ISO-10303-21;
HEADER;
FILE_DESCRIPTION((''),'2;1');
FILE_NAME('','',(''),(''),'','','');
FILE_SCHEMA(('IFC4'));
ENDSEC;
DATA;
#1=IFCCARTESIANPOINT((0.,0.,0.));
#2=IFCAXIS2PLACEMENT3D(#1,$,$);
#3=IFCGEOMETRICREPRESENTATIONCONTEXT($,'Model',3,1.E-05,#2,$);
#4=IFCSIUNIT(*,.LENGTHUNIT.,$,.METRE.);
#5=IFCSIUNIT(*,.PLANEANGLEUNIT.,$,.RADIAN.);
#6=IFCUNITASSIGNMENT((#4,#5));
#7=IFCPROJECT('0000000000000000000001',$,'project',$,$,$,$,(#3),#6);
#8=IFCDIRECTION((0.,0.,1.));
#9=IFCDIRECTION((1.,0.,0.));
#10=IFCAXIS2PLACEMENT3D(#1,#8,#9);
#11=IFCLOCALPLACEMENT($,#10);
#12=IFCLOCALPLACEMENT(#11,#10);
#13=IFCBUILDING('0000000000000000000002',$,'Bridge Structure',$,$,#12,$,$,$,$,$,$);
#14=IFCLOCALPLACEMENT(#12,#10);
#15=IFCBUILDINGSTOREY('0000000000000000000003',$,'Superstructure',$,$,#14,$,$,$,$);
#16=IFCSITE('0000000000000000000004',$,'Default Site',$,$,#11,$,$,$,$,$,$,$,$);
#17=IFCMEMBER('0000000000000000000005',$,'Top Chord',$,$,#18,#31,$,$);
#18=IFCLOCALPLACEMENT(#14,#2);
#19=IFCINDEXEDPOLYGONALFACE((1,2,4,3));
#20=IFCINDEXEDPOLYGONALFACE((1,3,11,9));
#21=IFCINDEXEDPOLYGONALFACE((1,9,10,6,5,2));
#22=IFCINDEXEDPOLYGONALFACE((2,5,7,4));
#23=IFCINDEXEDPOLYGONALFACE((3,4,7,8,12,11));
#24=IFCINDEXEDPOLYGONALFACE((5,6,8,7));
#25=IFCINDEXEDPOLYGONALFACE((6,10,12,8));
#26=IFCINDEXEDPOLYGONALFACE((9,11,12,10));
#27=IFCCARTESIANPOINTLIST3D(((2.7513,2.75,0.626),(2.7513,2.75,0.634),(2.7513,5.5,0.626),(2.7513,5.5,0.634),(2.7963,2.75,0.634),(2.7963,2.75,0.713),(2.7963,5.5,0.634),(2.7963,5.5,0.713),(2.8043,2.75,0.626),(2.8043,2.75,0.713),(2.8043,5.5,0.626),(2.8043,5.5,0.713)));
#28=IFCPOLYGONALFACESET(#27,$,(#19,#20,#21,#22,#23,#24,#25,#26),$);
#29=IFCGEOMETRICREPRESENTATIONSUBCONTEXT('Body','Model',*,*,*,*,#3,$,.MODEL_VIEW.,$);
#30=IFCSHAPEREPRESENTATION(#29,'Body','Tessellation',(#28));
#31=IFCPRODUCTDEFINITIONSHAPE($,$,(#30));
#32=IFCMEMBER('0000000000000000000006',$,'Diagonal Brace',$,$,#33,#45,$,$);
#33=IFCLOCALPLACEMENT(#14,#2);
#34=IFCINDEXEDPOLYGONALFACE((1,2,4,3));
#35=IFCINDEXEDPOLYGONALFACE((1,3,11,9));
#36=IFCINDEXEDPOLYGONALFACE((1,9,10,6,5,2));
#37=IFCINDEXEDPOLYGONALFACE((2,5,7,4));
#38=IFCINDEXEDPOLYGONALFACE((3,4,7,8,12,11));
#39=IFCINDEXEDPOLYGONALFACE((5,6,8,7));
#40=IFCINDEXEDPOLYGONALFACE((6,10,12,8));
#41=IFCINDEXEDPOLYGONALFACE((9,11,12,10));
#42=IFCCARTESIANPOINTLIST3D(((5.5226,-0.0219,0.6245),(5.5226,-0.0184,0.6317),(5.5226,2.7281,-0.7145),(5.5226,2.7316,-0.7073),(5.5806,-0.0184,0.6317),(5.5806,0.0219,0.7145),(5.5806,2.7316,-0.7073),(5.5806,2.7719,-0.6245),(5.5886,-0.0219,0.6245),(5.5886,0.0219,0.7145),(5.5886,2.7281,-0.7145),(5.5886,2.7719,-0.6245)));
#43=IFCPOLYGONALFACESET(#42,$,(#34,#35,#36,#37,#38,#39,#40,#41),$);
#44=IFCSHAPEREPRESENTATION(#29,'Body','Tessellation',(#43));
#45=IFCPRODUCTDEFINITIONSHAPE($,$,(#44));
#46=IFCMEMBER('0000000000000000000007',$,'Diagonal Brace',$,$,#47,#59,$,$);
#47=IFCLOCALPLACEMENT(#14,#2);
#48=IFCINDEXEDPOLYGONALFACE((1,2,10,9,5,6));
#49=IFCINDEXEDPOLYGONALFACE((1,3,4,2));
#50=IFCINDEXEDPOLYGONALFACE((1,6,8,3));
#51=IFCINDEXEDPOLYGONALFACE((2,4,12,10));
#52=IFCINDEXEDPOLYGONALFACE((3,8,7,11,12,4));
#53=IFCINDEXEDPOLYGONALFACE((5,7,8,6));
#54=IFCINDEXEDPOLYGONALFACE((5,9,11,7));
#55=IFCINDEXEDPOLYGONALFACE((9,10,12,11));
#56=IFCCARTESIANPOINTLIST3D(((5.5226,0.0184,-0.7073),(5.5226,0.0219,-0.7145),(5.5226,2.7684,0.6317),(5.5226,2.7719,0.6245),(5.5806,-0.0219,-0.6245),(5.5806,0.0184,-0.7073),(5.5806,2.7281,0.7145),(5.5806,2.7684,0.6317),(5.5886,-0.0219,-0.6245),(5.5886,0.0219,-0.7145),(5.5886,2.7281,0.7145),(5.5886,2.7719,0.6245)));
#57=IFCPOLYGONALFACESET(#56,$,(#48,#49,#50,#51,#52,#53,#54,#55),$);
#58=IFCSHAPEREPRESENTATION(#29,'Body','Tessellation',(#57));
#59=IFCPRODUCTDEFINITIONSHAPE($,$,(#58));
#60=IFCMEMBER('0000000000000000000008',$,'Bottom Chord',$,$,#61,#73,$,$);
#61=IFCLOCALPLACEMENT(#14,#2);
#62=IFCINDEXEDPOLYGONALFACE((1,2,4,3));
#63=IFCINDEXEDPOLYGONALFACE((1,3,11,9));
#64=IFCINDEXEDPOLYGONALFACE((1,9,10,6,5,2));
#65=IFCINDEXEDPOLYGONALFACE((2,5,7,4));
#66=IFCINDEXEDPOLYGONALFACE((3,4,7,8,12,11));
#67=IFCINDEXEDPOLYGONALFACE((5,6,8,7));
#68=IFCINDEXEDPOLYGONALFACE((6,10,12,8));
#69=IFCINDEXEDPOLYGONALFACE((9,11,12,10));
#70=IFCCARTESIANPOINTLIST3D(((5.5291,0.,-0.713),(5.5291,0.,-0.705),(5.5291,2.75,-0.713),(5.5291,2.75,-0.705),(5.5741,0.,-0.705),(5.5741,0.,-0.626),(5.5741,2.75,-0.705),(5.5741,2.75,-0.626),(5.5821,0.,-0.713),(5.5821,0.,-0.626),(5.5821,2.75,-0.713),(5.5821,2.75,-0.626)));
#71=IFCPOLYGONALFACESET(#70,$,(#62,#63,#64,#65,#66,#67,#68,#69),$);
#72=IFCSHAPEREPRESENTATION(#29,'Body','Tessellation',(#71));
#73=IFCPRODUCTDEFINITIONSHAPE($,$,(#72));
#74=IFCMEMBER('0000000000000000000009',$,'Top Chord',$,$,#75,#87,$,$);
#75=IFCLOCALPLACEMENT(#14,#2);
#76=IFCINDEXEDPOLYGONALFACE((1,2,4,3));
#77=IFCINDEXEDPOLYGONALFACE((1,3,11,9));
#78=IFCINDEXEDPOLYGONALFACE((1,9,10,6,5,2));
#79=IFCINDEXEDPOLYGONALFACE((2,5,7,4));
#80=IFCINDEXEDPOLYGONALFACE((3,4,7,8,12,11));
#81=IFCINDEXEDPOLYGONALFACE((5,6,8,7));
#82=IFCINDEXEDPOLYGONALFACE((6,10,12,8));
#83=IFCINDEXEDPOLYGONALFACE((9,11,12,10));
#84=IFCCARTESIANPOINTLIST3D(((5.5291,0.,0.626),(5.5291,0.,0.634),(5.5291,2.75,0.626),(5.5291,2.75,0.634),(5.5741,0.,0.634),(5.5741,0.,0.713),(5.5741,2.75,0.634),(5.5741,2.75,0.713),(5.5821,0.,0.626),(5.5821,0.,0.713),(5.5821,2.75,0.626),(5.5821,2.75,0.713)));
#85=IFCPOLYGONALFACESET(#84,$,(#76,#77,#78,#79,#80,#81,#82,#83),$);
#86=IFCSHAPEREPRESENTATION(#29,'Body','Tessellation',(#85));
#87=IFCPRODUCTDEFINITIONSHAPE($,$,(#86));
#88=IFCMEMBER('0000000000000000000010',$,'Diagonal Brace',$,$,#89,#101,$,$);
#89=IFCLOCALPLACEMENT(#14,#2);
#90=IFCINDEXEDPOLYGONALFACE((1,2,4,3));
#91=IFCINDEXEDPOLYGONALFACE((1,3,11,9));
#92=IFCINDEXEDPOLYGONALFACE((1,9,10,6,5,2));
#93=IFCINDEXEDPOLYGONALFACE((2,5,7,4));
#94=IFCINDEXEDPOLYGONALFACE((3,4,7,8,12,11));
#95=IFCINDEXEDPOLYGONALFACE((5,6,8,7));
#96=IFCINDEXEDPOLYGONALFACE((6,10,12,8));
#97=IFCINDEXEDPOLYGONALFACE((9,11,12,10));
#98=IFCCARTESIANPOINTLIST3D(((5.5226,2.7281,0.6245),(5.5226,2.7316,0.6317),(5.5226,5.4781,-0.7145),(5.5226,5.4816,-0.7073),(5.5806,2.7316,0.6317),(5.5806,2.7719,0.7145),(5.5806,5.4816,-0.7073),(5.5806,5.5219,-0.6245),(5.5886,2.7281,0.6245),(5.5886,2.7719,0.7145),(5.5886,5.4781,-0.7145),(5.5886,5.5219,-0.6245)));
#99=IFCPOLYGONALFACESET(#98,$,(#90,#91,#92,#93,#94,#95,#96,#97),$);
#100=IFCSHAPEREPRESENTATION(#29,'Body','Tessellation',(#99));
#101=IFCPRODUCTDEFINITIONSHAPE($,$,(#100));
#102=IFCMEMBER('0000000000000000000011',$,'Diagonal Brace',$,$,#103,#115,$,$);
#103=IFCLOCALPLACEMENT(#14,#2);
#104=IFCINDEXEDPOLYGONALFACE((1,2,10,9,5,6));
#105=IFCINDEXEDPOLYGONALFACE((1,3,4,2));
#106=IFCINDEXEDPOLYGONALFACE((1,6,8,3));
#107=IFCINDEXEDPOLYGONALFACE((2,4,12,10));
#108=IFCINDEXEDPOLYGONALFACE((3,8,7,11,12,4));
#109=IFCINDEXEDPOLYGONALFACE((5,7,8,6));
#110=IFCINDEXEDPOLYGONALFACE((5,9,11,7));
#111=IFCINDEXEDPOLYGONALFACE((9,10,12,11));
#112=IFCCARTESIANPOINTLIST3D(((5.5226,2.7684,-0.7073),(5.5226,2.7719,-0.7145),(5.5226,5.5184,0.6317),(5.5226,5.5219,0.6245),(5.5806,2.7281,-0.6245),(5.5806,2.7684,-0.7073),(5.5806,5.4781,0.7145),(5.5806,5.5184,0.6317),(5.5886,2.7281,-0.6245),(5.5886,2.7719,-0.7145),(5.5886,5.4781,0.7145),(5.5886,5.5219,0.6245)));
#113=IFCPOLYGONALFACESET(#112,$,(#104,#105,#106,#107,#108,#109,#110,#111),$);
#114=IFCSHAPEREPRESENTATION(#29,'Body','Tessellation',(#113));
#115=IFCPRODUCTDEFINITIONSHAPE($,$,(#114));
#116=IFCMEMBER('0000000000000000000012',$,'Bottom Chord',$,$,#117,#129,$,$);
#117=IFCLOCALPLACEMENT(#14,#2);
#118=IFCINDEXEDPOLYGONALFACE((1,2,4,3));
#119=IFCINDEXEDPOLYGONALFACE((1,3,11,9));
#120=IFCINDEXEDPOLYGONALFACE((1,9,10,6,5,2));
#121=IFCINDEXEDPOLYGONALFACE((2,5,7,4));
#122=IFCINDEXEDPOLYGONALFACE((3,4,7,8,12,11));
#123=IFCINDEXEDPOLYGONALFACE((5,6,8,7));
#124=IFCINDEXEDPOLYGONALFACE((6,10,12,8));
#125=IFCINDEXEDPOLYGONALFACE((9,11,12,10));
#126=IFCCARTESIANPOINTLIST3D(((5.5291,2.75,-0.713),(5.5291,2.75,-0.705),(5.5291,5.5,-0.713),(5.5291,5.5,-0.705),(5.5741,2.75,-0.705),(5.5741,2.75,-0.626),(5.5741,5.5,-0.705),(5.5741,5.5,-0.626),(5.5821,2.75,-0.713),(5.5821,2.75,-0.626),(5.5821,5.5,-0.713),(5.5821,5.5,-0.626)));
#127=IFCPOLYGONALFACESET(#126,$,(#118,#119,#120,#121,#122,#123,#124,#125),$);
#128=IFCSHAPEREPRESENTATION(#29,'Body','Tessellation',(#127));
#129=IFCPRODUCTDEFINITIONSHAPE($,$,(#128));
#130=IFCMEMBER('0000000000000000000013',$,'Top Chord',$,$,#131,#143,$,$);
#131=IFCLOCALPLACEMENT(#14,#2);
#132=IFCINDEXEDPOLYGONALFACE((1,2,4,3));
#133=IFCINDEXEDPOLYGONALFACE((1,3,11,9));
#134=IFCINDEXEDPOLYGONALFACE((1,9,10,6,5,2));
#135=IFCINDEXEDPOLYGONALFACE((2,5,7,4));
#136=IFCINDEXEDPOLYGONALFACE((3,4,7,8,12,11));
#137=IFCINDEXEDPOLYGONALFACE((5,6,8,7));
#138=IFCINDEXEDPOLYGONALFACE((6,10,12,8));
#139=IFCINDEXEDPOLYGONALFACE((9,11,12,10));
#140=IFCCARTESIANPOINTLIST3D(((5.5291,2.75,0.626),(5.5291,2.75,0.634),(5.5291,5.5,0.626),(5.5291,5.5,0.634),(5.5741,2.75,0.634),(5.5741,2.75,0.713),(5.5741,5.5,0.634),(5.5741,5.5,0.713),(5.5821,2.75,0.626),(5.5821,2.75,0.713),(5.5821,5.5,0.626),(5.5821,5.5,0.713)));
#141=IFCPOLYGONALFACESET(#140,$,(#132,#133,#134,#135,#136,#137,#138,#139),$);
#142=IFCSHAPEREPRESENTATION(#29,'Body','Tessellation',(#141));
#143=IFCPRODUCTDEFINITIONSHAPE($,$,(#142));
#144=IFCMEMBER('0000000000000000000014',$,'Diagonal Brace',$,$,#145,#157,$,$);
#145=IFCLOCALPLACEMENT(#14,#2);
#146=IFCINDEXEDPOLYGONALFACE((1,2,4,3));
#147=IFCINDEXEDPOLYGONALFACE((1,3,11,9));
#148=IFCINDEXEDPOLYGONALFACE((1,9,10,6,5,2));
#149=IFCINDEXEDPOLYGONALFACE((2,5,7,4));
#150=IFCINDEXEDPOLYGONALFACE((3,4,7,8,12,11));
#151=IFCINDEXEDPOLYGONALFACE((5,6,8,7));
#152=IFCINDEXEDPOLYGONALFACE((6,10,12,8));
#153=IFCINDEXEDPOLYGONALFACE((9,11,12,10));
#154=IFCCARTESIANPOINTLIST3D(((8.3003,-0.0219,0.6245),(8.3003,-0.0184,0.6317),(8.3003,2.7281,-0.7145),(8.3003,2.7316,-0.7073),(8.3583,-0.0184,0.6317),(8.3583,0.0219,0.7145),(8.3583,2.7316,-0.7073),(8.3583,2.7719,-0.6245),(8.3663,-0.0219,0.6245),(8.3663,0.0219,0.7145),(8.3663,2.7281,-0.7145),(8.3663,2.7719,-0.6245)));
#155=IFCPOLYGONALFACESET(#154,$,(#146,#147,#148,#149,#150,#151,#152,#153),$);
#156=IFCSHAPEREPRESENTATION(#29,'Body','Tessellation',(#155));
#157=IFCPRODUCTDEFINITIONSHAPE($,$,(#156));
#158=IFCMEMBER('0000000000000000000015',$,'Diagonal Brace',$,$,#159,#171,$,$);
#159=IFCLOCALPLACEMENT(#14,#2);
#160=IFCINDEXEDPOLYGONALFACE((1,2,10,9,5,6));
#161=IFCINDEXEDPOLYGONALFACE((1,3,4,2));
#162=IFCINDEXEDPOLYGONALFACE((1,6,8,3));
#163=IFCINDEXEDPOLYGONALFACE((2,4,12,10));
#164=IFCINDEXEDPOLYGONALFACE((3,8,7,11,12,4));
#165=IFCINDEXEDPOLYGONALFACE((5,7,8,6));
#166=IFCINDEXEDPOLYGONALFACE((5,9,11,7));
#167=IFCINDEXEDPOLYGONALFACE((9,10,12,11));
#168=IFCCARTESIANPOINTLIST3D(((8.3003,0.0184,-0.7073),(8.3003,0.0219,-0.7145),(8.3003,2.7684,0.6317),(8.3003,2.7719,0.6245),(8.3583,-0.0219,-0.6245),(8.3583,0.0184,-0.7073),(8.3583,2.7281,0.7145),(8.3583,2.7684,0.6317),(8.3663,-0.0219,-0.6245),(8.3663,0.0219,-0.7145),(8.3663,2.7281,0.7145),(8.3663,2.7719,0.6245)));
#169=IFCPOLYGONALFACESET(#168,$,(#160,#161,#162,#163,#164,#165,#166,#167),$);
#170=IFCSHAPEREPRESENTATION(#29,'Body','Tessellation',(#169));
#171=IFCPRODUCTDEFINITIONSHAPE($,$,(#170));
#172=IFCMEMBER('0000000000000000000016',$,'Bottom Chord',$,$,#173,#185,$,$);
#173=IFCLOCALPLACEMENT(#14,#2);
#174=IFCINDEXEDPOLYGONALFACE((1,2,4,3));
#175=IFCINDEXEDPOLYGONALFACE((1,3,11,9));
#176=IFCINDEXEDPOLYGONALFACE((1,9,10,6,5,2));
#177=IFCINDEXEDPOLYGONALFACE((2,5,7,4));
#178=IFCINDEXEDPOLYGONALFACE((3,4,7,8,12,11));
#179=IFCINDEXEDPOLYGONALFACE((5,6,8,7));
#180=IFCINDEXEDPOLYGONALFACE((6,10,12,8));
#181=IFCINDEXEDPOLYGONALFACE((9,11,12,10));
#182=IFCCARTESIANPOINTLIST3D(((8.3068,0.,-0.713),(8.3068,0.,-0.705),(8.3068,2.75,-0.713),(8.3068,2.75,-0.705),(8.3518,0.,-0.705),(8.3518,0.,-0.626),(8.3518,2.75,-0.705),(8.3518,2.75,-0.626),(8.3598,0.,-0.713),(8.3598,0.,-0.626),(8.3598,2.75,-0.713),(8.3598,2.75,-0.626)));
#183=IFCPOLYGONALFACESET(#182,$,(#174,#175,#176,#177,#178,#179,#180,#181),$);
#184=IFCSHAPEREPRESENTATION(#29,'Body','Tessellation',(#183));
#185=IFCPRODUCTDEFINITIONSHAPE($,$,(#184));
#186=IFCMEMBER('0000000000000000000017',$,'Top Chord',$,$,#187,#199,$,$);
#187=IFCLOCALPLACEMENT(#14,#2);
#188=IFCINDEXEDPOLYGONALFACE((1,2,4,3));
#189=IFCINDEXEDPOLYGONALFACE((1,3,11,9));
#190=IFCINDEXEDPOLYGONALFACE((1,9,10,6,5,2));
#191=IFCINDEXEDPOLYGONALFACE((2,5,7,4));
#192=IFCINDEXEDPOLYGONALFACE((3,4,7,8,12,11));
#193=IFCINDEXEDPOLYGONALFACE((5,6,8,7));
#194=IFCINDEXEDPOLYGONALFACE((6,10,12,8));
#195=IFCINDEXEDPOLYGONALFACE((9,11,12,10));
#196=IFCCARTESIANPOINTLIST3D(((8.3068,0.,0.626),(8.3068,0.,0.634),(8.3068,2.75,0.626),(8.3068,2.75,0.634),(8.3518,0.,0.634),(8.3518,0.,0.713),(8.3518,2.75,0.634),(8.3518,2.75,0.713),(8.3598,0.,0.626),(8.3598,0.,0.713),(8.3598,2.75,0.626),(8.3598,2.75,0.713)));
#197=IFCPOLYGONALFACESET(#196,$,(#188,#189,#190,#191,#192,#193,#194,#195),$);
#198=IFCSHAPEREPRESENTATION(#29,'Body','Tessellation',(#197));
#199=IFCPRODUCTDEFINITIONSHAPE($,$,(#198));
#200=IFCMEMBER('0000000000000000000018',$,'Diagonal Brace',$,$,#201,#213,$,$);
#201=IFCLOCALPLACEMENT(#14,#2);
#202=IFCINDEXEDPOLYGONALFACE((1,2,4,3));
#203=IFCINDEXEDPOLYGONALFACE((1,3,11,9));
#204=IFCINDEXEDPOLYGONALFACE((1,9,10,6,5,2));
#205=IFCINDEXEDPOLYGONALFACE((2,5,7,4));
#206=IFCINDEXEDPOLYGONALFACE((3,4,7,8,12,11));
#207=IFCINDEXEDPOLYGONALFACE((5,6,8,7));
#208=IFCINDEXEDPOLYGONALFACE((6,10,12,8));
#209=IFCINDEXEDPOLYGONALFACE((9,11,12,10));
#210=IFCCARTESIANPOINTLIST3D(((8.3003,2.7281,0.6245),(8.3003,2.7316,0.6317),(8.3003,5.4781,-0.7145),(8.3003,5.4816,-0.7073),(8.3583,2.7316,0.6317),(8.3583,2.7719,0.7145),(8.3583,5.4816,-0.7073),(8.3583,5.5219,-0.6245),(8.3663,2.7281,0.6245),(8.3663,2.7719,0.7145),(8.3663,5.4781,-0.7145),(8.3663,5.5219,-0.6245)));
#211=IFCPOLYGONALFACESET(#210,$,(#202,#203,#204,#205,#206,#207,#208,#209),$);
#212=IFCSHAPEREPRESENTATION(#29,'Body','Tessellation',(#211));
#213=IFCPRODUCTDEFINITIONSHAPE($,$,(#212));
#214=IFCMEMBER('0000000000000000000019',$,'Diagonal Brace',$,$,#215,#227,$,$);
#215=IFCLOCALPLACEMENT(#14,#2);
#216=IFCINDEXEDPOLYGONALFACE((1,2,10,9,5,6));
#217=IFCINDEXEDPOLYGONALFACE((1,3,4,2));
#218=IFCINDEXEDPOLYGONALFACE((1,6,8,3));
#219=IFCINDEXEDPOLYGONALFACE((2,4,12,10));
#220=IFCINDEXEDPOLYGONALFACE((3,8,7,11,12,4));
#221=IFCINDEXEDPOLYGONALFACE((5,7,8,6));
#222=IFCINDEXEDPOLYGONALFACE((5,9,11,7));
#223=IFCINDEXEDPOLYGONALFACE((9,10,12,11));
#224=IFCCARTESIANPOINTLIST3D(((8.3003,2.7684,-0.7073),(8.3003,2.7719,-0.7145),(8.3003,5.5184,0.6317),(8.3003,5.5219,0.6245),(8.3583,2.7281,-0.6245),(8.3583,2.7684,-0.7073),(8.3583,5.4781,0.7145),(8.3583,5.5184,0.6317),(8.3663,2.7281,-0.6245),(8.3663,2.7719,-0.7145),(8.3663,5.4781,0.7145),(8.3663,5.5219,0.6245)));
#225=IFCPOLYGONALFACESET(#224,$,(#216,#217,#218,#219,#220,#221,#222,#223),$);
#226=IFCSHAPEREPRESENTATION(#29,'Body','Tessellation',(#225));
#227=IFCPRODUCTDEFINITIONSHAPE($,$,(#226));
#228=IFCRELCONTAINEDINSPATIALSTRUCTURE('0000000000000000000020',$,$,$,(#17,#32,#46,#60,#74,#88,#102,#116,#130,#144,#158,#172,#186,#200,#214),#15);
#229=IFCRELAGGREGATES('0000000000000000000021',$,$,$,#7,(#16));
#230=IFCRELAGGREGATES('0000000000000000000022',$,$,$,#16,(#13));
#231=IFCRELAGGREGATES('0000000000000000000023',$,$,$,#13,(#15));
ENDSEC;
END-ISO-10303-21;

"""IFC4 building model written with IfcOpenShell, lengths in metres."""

from ifc_helpers import new_model, si_unit, frame, origin, origin_with_axes, origin_2d_with_axis, place, context, subcontext, project, spatial, l_section, extrude, element, save


model = new_model("IFC4")

# Units and contexts
model_context = context("Model", 3, precision=1e-05, world=origin())
body_context = subcontext(model_context, "Body", "Model", "MODEL_VIEW")
ifc_project = project(units=[si_unit("LENGTHUNIT", "METRE"), si_unit("PLANEANGLEUNIT", "RADIAN")], contexts=[model_context])

# Site, building, storey
site_placement = place(None, origin_with_axes())
site = spatial("IfcSite", under=ifc_project, at=site_placement, Name="Default Site")
building_placement = place(site_placement, origin_with_axes())
building = spatial("IfcBuilding", under=site, at=building_placement, Name="Bridge Structure")
storey_placement = place(building_placement, origin_with_axes())
storey = spatial("IfcBuildingStorey", under=building, at=storey_placement, Name="Superstructure")

# Members
member_placement = place(storey_placement, frame((2.7778, 2.75, 0.6695), z_axis=(0.0, 1.0, 0.0), x_axis=(-1.0, 0.0, 0.0)))
element("IfcMember", 1, at=member_placement, inside=storey, Name="Top Chord", context=body_context, shape_type="SweptSolid", body=[
    extrude(l_section(Depth=0.087, Width=0.053, Thickness=0.008, at=origin_2d_with_axis()), origin_with_axes(), (0.0, 0.0, 1.0), 2.75),
])
for number, where, z_axis, x_axis, name in (
    (2, (5.5556, 0.0, 0.6695), (0.0, 0.899086, -0.437773), (-1.0, 0.0, 0.0), "Diagonal Brace"),
    (3, (5.5556, 0.0, -0.6695), (0.0, 0.899086, 0.437773), (-1.0, 0.0, 0.0), "Diagonal Brace"),
):
    element("IfcMember", number, at=place(storey_placement, frame(where, z_axis=z_axis, x_axis=x_axis)), inside=storey, Name=name, context=body_context, shape_type="SweptSolid", body=[
        extrude(l_section(Depth=0.1, Width=0.066, Thickness=0.008, at=origin_2d_with_axis()), origin_with_axes(), (0.0, 0.0, 1.0), 3.0587),
    ])
for number, where, z_axis, x_axis, name in (
    (4, (5.5556, 0.0, -0.6695), (0.0, 1.0, 0.0), (-1.0, 0.0, 0.0), "Bottom Chord"),
    (5, (5.5556, 0.0, 0.6695), (0.0, 1.0, 0.0), (-1.0, 0.0, 0.0), "Top Chord"),
):
    element("IfcMember", number, at=place(storey_placement, frame(where, z_axis=z_axis, x_axis=x_axis)), inside=storey, Name=name, context=body_context, shape_type="SweptSolid", body=[
        extrude(l_section(Depth=0.087, Width=0.053, Thickness=0.008, at=origin_2d_with_axis()), origin_with_axes(), (0.0, 0.0, 1.0), 2.75),
    ])
for number, where, z_axis, x_axis, name in (
    (6, (5.5556, 2.75, 0.6695), (0.0, 0.899086, -0.437773), (-1.0, 0.0, 0.0), "Diagonal Brace"),
    (7, (5.5556, 2.75, -0.6695), (0.0, 0.899086, 0.437773), (-1.0, 0.0, 0.0), "Diagonal Brace"),
):
    element("IfcMember", number, at=place(storey_placement, frame(where, z_axis=z_axis, x_axis=x_axis)), inside=storey, Name=name, context=body_context, shape_type="SweptSolid", body=[
        extrude(l_section(Depth=0.1, Width=0.066, Thickness=0.008, at=origin_2d_with_axis()), origin_with_axes(), (0.0, 0.0, 1.0), 3.0587),
    ])
for number, where, z_axis, x_axis, name in (
    (8, (5.5556, 2.75, -0.6695), (0.0, 1.0, 0.0), (-1.0, 0.0, 0.0), "Bottom Chord"),
    (9, (5.5556, 2.75, 0.6695), (0.0, 1.0, 0.0), (-1.0, 0.0, 0.0), "Top Chord"),
):
    element("IfcMember", number, at=place(storey_placement, frame(where, z_axis=z_axis, x_axis=x_axis)), inside=storey, Name=name, context=body_context, shape_type="SweptSolid", body=[
        extrude(l_section(Depth=0.087, Width=0.053, Thickness=0.008, at=origin_2d_with_axis()), origin_with_axes(), (0.0, 0.0, 1.0), 2.75),
    ])
for number, where, z_axis, x_axis, name in (
    (10, (8.3333, 0.0, 0.6695), (0.0, 0.899086, -0.437773), (-1.0, 0.0, 0.0), "Diagonal Brace"),
    (11, (8.3333, 0.0, -0.6695), (0.0, 0.899086, 0.437773), (-1.0, 0.0, 0.0), "Diagonal Brace"),
):
    element("IfcMember", number, at=place(storey_placement, frame(where, z_axis=z_axis, x_axis=x_axis)), inside=storey, Name=name, context=body_context, shape_type="SweptSolid", body=[
        extrude(l_section(Depth=0.1, Width=0.066, Thickness=0.008, at=origin_2d_with_axis()), origin_with_axes(), (0.0, 0.0, 1.0), 3.0587),
    ])
for number, where, z_axis, x_axis, name in (
    (12, (8.3333, 0.0, -0.6695), (0.0, 1.0, 0.0), (-1.0, 0.0, 0.0), "Bottom Chord"),
    (13, (8.3333, 0.0, 0.6695), (0.0, 1.0, 0.0), (-1.0, 0.0, 0.0), "Top Chord"),
):
    element("IfcMember", number, at=place(storey_placement, frame(where, z_axis=z_axis, x_axis=x_axis)), inside=storey, Name=name, context=body_context, shape_type="SweptSolid", body=[
        extrude(l_section(Depth=0.087, Width=0.053, Thickness=0.008, at=origin_2d_with_axis()), origin_with_axes(), (0.0, 0.0, 1.0), 2.75),
    ])
for number, where, z_axis, x_axis, name in (
    (14, (8.3333, 2.75, 0.6695), (0.0, 0.899086, -0.437773), (-1.0, 0.0, 0.0), "Diagonal Brace"),
    (15, (8.3333, 2.75, -0.6695), (0.0, 0.899086, 0.437773), (-1.0, 0.0, 0.0), "Diagonal Brace"),
):
    element("IfcMember", number, at=place(storey_placement, frame(where, z_axis=z_axis, x_axis=x_axis)), inside=storey, Name=name, context=body_context, shape_type="SweptSolid", body=[
        extrude(l_section(Depth=0.1, Width=0.066, Thickness=0.008, at=origin_2d_with_axis()), origin_with_axes(), (0.0, 0.0, 1.0), 3.0587),
    ])

save(model, "model.ifc")
